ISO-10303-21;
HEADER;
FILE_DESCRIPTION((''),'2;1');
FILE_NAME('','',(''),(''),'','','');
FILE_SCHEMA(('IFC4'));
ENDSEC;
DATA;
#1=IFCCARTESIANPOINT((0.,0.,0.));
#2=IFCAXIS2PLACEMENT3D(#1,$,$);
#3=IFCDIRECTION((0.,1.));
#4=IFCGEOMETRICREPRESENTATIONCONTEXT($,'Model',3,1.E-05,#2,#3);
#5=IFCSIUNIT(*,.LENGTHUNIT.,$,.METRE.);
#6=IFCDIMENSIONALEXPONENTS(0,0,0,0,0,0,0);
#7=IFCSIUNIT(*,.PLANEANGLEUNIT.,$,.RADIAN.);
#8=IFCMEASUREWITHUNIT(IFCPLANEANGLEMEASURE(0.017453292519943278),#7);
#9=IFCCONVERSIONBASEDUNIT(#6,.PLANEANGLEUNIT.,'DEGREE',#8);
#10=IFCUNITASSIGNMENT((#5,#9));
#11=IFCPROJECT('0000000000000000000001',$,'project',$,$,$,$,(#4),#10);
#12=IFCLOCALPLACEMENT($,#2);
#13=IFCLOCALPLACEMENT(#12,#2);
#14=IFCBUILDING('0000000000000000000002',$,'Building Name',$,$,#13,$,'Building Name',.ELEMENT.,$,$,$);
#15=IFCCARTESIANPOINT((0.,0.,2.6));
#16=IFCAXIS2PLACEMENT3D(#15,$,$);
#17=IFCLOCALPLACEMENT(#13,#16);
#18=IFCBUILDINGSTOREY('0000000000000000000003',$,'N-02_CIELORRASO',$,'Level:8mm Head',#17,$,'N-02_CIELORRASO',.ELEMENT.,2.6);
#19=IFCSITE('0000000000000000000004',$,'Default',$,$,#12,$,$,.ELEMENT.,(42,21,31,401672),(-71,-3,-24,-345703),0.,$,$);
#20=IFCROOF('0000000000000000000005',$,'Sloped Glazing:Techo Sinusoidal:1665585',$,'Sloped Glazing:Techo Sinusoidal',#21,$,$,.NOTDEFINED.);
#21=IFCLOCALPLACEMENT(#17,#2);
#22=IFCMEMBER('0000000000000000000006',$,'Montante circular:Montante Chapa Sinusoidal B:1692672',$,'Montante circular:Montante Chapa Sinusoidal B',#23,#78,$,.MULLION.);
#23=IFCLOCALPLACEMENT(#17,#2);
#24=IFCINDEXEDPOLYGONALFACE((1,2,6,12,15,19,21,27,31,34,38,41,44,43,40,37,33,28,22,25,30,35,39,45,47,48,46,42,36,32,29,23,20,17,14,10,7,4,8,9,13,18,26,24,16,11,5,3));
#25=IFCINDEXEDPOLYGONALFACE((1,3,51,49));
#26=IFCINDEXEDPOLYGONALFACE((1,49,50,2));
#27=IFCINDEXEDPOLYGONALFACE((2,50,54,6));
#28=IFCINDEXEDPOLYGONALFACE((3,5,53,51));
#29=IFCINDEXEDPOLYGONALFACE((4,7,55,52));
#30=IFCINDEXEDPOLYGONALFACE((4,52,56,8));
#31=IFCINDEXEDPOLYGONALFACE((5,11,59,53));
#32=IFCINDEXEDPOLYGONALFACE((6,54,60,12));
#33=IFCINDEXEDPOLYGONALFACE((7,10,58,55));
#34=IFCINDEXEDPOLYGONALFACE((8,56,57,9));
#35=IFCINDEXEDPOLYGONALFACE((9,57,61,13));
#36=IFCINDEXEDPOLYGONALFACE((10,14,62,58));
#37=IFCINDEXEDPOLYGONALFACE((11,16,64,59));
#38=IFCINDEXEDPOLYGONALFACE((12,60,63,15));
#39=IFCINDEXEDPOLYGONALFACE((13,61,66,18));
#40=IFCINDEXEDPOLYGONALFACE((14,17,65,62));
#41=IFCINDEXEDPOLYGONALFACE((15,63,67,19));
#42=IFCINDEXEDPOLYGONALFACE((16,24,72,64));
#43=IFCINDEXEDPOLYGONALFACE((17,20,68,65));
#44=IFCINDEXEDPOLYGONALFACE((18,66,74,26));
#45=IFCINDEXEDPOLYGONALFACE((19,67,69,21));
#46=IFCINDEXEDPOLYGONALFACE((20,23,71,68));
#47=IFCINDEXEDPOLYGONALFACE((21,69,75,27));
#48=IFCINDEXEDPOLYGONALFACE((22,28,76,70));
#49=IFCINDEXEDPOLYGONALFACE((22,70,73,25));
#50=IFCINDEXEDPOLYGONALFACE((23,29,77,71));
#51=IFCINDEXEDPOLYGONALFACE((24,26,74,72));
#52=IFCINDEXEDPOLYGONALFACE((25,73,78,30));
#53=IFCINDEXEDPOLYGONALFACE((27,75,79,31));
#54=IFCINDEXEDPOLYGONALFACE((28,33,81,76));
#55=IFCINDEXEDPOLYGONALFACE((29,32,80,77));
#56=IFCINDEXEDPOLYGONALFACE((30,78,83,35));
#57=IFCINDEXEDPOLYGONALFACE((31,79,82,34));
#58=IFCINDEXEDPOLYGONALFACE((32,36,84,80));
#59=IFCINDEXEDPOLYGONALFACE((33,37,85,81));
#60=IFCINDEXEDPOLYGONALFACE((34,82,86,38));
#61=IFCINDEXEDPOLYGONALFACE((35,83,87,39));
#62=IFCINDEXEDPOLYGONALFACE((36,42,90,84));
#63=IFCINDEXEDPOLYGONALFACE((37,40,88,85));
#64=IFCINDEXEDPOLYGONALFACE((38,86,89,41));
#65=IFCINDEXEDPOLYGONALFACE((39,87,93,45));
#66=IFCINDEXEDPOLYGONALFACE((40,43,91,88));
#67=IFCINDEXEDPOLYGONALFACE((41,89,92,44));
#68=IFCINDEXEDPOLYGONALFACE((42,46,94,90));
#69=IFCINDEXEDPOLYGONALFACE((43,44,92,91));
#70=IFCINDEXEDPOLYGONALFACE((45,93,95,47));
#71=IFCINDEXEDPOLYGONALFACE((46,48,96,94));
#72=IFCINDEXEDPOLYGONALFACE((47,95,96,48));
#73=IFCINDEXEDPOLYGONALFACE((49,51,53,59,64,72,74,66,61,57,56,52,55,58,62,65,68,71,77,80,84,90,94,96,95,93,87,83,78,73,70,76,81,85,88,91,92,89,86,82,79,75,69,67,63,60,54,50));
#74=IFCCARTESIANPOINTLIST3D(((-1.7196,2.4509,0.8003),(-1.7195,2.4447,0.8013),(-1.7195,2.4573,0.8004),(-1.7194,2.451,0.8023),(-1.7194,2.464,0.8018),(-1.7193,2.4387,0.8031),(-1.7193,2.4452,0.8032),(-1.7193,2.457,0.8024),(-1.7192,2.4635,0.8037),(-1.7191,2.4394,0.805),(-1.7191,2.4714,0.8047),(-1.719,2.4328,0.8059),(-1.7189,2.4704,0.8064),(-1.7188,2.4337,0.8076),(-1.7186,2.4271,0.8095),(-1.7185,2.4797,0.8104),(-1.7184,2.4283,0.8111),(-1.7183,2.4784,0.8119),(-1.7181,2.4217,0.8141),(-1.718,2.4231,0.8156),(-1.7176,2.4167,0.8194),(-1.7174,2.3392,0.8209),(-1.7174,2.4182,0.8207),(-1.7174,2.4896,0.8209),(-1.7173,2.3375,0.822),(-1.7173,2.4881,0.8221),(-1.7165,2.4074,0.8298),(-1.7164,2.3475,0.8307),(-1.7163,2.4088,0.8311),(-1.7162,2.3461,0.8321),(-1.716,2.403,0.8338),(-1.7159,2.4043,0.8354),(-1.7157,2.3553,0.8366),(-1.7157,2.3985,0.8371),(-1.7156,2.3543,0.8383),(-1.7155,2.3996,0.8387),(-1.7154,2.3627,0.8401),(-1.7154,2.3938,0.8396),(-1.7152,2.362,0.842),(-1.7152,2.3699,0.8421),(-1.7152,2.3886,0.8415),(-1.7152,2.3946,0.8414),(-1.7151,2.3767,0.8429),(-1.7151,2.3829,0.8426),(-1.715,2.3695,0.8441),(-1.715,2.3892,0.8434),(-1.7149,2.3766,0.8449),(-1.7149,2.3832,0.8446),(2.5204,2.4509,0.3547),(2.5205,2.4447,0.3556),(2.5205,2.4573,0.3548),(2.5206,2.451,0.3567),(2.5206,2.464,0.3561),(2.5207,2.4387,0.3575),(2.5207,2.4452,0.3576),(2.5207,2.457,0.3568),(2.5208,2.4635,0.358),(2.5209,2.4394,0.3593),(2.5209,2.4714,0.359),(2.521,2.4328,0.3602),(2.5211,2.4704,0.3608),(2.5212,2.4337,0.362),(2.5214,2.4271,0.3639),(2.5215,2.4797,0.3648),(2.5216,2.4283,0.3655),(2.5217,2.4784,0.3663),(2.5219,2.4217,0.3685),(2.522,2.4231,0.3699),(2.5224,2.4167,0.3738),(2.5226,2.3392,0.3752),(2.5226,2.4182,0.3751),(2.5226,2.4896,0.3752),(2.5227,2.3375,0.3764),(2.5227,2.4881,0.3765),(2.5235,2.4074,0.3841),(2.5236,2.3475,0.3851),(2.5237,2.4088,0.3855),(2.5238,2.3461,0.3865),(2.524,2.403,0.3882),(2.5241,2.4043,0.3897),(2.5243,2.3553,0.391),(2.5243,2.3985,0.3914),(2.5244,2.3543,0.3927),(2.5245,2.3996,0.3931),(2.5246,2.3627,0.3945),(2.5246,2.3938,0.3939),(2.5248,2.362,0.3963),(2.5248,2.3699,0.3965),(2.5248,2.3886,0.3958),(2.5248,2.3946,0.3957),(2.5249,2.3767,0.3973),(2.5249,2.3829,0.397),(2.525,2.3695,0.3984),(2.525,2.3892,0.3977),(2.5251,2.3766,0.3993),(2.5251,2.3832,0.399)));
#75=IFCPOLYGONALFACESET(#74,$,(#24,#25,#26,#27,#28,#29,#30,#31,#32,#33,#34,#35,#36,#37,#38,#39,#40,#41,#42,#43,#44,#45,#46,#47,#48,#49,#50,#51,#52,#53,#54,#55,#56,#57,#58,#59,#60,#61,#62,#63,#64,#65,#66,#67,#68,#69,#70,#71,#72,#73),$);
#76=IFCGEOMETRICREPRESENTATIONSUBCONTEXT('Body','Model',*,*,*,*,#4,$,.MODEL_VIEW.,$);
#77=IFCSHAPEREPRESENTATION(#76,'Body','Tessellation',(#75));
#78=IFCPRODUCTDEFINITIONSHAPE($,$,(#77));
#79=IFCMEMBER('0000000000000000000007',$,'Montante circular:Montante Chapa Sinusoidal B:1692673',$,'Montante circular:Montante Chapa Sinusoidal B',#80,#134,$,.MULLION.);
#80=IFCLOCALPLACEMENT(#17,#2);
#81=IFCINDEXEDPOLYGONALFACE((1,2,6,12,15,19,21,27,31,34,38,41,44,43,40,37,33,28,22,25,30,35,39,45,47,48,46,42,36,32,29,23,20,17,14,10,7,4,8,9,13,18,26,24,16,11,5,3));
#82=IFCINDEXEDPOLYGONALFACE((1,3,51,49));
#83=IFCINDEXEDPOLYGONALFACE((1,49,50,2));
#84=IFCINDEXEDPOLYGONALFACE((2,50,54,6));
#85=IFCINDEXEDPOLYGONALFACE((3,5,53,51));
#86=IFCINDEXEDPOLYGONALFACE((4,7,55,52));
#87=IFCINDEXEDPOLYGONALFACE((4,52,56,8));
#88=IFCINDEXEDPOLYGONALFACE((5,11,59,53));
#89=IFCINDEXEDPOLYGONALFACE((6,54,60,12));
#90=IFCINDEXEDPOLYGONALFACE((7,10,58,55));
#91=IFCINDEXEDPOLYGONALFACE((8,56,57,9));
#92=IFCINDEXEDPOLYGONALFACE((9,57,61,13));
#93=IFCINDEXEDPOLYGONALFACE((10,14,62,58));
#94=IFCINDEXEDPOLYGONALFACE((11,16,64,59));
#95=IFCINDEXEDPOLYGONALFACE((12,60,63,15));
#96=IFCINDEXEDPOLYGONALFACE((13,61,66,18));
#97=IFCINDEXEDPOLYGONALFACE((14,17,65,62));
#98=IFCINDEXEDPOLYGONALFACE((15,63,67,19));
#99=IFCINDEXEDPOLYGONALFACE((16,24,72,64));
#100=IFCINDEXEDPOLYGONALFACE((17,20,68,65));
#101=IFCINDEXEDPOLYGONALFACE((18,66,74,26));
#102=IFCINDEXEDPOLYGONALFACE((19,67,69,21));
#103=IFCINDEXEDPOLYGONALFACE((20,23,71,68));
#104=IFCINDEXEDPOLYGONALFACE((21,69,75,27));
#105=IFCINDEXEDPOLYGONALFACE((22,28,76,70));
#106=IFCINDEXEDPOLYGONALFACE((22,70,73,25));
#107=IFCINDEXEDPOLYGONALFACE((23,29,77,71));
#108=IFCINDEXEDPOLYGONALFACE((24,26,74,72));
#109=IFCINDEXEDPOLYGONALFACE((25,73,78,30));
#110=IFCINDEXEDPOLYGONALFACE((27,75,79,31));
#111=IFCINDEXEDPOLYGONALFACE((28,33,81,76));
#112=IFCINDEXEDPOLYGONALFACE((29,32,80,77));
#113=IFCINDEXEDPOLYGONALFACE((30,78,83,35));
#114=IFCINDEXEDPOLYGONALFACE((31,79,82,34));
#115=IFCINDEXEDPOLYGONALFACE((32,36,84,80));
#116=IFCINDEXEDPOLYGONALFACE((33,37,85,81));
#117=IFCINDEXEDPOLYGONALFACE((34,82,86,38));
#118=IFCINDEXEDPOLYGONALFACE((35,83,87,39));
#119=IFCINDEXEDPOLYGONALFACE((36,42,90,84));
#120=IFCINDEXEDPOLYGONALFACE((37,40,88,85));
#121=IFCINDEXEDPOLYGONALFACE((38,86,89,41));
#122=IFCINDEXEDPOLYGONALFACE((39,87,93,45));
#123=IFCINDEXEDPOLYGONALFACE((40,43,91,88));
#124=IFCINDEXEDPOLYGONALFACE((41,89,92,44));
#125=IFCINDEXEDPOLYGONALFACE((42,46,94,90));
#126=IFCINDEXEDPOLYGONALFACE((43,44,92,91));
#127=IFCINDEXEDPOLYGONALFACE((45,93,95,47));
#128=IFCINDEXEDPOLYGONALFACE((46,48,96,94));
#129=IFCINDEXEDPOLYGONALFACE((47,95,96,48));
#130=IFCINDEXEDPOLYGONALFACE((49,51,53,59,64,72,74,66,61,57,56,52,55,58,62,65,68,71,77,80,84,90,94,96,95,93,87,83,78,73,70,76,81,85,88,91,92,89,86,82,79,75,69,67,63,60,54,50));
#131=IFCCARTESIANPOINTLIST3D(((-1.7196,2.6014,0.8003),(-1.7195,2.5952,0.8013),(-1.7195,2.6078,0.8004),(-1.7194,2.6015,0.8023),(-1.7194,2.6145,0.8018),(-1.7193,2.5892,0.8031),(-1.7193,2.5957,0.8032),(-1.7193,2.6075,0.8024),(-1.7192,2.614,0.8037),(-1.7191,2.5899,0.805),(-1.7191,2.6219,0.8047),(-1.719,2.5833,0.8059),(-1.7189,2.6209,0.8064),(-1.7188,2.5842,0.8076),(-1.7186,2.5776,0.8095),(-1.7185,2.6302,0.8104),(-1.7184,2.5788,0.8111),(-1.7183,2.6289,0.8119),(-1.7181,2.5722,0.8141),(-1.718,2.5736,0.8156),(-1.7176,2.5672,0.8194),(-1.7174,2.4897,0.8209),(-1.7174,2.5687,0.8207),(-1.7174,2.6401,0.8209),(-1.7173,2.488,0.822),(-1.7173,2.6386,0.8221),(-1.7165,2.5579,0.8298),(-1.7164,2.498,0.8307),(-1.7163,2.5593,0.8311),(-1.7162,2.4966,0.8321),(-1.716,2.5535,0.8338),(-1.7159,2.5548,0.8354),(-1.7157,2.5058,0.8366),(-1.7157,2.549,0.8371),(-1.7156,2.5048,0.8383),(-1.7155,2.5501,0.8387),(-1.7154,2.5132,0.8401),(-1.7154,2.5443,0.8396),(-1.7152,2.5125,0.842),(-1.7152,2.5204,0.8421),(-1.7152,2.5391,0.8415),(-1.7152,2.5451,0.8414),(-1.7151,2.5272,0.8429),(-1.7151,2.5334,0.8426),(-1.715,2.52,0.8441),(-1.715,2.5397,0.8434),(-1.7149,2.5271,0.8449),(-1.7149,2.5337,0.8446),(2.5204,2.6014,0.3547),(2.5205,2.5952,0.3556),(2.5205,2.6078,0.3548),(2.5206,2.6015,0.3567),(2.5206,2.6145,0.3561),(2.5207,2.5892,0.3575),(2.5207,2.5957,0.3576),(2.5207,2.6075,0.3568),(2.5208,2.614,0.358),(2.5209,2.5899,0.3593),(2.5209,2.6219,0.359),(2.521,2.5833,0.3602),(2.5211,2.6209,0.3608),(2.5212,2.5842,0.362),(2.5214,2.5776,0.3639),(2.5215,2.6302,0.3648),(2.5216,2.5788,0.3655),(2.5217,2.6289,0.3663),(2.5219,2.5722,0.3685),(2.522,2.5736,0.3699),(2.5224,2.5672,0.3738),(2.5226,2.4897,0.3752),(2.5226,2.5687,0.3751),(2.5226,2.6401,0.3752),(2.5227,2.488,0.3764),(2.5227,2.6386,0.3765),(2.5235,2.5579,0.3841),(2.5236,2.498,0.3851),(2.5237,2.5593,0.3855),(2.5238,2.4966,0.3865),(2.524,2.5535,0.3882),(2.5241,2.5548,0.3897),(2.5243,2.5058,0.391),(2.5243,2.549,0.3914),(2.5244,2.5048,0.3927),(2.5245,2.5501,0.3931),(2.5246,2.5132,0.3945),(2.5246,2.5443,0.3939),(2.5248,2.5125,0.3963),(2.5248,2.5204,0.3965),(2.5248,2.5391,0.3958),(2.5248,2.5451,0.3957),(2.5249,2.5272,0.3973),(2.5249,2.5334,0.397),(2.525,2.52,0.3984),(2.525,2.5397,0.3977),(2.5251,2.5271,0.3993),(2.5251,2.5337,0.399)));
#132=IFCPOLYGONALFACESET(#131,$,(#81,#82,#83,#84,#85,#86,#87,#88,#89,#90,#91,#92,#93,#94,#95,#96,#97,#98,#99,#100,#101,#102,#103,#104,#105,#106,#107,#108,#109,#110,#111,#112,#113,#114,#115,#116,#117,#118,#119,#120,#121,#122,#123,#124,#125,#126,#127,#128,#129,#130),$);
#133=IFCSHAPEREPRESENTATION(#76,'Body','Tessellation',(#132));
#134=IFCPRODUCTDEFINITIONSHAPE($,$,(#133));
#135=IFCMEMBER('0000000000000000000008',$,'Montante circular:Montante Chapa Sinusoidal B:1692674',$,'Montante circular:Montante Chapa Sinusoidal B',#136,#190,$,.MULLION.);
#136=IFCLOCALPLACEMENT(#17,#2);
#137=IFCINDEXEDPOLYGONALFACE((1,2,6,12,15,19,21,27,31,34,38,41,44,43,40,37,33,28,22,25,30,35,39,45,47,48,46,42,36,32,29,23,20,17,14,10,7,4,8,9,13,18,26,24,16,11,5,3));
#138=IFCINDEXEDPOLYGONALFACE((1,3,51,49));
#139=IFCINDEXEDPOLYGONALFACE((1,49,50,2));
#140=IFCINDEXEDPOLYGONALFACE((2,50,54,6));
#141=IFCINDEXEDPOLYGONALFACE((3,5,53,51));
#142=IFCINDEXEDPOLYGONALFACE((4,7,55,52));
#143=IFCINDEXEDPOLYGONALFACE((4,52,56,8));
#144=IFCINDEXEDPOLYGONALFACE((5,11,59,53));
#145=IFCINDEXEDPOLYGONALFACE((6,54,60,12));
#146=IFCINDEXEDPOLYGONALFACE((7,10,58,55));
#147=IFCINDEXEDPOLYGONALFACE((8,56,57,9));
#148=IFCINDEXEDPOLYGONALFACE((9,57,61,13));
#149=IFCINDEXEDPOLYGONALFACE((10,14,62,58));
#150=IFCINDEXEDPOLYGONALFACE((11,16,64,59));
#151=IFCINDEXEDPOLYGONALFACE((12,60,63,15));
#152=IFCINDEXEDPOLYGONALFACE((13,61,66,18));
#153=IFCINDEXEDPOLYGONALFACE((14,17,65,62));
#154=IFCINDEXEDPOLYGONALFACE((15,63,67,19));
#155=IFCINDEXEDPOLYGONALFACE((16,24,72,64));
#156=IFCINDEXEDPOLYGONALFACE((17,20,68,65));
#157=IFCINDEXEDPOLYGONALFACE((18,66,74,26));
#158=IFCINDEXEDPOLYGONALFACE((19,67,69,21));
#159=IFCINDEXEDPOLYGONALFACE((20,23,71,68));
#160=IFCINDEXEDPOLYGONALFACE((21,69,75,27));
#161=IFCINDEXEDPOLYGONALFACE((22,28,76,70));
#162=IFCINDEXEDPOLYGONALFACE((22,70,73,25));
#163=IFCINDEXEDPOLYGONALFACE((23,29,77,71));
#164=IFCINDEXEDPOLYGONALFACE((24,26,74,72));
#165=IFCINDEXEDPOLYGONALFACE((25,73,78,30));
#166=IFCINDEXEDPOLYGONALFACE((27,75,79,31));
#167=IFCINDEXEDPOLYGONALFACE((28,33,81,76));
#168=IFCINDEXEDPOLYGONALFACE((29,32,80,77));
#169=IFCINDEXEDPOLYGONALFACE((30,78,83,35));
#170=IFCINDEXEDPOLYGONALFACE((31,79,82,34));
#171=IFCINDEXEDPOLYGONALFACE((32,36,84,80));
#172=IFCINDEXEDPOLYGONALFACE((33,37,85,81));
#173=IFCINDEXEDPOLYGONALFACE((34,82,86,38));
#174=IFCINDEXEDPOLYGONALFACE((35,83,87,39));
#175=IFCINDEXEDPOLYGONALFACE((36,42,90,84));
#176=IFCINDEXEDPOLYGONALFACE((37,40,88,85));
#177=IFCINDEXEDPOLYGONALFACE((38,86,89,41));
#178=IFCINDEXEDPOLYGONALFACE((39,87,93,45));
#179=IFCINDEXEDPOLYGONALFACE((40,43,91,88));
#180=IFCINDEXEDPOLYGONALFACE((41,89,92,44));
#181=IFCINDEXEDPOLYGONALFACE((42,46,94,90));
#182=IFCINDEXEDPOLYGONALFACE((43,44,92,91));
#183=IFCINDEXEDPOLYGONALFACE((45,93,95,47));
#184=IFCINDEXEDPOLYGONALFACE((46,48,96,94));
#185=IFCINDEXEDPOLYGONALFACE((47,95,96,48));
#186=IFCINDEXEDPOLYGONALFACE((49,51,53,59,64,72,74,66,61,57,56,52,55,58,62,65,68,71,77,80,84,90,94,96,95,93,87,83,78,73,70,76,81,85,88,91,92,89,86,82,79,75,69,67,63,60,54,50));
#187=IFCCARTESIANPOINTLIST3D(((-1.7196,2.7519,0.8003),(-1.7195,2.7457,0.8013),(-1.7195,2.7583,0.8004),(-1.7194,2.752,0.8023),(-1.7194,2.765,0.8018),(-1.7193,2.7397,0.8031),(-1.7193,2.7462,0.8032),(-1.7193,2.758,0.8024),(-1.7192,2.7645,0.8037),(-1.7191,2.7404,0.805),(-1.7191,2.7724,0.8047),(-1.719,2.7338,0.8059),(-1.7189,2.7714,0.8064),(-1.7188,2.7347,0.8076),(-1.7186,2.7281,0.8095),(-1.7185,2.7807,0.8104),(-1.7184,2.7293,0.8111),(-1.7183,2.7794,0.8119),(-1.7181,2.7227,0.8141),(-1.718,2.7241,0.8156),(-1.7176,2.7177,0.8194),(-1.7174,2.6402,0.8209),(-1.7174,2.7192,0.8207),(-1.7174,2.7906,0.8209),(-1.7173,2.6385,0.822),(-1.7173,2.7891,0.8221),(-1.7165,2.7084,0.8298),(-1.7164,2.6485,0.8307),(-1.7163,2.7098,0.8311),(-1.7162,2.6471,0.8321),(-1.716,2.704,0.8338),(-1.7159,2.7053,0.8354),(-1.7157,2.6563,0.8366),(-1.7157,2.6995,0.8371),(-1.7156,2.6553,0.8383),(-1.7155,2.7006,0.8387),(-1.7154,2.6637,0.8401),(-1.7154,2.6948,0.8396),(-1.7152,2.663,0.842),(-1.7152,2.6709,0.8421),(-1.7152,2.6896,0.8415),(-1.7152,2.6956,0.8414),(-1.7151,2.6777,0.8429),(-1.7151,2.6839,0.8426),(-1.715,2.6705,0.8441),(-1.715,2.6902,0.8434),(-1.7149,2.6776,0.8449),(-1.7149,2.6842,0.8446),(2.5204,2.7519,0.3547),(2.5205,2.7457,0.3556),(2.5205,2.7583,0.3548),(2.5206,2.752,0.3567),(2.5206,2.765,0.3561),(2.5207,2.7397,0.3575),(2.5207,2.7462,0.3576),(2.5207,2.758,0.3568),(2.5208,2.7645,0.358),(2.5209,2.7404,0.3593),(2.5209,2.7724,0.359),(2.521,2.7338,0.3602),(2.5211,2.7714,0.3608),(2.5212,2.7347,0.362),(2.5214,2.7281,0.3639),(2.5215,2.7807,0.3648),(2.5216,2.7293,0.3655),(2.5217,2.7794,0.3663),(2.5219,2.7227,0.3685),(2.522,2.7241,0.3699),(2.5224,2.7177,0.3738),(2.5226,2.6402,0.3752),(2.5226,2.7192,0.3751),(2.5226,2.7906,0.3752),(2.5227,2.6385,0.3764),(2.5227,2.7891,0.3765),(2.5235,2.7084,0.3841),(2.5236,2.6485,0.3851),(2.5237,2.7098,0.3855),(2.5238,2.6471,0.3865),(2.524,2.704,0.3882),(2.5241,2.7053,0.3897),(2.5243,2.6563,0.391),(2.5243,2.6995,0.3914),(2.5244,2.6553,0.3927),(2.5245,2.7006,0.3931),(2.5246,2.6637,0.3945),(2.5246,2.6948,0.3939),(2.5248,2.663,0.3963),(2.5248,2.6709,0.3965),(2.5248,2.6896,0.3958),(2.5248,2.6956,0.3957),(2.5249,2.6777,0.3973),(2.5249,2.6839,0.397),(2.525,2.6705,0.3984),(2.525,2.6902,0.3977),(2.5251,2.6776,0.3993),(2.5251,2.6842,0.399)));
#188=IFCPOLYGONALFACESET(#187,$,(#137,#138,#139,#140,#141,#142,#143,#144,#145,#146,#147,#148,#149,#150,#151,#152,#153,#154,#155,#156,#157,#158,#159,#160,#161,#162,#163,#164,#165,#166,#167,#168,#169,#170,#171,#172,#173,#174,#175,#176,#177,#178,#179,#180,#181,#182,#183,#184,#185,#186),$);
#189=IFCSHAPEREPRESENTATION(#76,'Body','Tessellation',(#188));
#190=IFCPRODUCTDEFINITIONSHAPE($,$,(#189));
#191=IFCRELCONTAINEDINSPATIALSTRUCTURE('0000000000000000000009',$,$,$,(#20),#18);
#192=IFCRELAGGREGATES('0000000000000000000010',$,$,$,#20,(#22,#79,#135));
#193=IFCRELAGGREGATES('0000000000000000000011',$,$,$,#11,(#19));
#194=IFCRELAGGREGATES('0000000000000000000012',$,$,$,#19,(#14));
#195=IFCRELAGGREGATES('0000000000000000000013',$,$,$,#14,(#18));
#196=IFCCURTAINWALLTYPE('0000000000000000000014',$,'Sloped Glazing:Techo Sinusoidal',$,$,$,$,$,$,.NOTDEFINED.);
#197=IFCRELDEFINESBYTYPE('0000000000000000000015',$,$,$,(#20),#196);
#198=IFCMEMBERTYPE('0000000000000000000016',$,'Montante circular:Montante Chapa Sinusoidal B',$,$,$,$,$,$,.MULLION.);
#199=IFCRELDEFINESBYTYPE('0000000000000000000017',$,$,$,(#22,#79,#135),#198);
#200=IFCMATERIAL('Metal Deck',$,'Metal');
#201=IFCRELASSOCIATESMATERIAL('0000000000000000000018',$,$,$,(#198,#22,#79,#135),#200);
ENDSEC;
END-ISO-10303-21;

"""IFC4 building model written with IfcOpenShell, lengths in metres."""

from ifc_helpers import new_model, entity, si_unit, converted_unit, direction, frame, origin, place, context, subcontext, project, spatial, indexed_curve, outline, extrude, source, transform, mapped, material, type_object, type_shapes, element, aggregate, save


model = new_model("IFC4")

# Units and contexts
model_context = context("Model", 3, precision=1e-05, world=origin(), true_north=direction((0.0, 1.0)))
body_context = subcontext(model_context, "Body", "Model", "MODEL_VIEW")
ifc_project = project(units=[si_unit("LENGTHUNIT", "METRE"), converted_unit("PLANEANGLEUNIT", "DEGREE", entity("IfcPlaneAngleMeasure", 0.017453292519943278), si_unit("PLANEANGLEUNIT", "RADIAN"), dimensions=[0, 0, 0, 0, 0, 0, 0])], contexts=[model_context])

# Site, building, storey
site_placement = place(None, origin())
site = spatial("IfcSite", under=ifc_project, at=site_placement, Name="Default", CompositionType="ELEMENT", RefLatitude=(42, 21, 31, 401672), RefLongitude=(-71, -3, -24, -345703), RefElevation=0.0)
building_placement = place(site_placement, origin())
building = spatial("IfcBuilding", under=site, at=building_placement, Name="Building Name", LongName="Building Name", CompositionType="ELEMENT")
storey_placement = place(building_placement, frame((0.0, 0.0, 2.6)))
storey = spatial("IfcBuildingStorey", under=building, at=storey_placement, Name="N-02_CIELORRASO", ObjectType="Level:8mm Head", LongName="N-02_CIELORRASO", CompositionType="ELEMENT", Elevation=2.6)

# Roof, members
curtain_wall_type = type_object("IfcCurtainWallType", Name="Sloped Glazing:Techo Sinusoidal", PredefinedType="NOTDEFINED")
roof_placement = place(storey_placement, frame((0.0, 0.0, -2.6)))
roof = element("IfcRoof", 1, at=roof_placement, inside=storey, type_object=curtain_wall_type, Name="Sloped Glazing:Techo Sinusoidal:1665585", ObjectType="Sloped Glazing:Techo Sinusoidal", PredefinedType="NOTDEFINED")
ifc_material_1 = material(Name="Metal Deck", Category="Metal")
member_type = type_object("IfcMemberType", Name="Montante circular:Montante Chapa Sinusoidal B", PredefinedType="MULLION", material=ifc_material_1)
shared_shape_1 = source(origin(), body_context, "Body", "SweptSolid", [
    extrude(outline(indexed_curve([(0.0595, -0.0443), (0.0615, -0.0443), (0.0603, -0.031), (0.0572, -0.0213), (0.053, -0.0138), (0.0481, -0.0078), (0.0427, -0.003), (0.0372, 0.0005), (0.0315, 0.0029), (0.0259, 0.0044), (0.0203, 0.0051), (0.0146, 0.005), (0.0084, 0.0041), (-0.0053, 0.0009), (-0.0123, -0.0005), (-0.0191, -0.0012), (-0.0256, -0.001), (-0.0317, 0.0001), (-0.0375, 0.0019), (-0.0428, 0.0046), (-0.0477, 0.0081), (-0.0522, 0.0128), (-0.0563, 0.0191), (-0.0597, 0.0282), (-0.0617, 0.0421), (-0.0637, 0.042), (-0.0616, 0.0277), (-0.0581, 0.0182), (-0.0537, 0.0116), (-0.049, 0.0066), (-0.0438, 0.0028), (-0.0382, 0.0001), (-0.0322, -0.0019), (-0.0258, -0.003), (-0.019, -0.0032), (-0.012, -0.0025), (-0.0048, -0.0011), (0.0088, 0.0021), (0.0147, 0.003), (0.0202, 0.0031), (0.0255, 0.0024), (0.0309, 0.001), (0.0362, -0.0013), (0.0415, -0.0046), (0.0466, -0.0092), (0.0513, -0.0149), (0.0554, -0.0221), (0.0584, -0.0314), (0.0595, -0.0443)], self_intersect=False)), frame((-0.007, 0.0228, -4.2634), z_axis=(0.0, 0.0, 1.0), x_axis=(-0.819152, -0.573576, 0.0)), (0.0, 0.0, 1.0), 4.2634),
])
type_shapes(member_type, [shared_shape_1])
member_1_placement = place(roof_placement, frame((-1.7148, 2.4204, 3.4456), z_axis=(-0.994522, 0.0, 0.104528), x_axis=(0.0, 1.0, 0.0)))
member_1 = element("IfcMember", 2, at=member_1_placement, type_object=member_type, material=ifc_material_1, Name="Montante circular:Montante Chapa Sinusoidal B:1692672", ObjectType="Montante circular:Montante Chapa Sinusoidal B", PredefinedType="MULLION", context=body_context, shape_type="MappedRepresentation", body=[
    mapped(shared_shape_1, transform((0.0, 0.0, 0.0), scale=1.0)),
])
member_2_placement = place(roof_placement, frame((-1.7148, 2.5709, 3.4456), z_axis=(-0.994522, 0.0, 0.104528), x_axis=(0.0, 1.0, 0.0)))
member_2 = element("IfcMember", 3, at=member_2_placement, type_object=member_type, material=ifc_material_1, Name="Montante circular:Montante Chapa Sinusoidal B:1692673", ObjectType="Montante circular:Montante Chapa Sinusoidal B", PredefinedType="MULLION", context=body_context, shape_type="MappedRepresentation", body=[
    mapped(shared_shape_1, transform((0.0, 0.0, 0.0), scale=1.0)),
])
member_3_placement = place(roof_placement, frame((-1.7148, 2.7214, 3.4456), z_axis=(-0.994522, 0.0, 0.104528), x_axis=(0.0, 1.0, 0.0)))
member_3 = element("IfcMember", 4, at=member_3_placement, type_object=member_type, material=ifc_material_1, Name="Montante circular:Montante Chapa Sinusoidal B:1692674", ObjectType="Montante circular:Montante Chapa Sinusoidal B", PredefinedType="MULLION", context=body_context, shape_type="MappedRepresentation", body=[
    mapped(shared_shape_1, transform((0.0, 0.0, 0.0), scale=1.0)),
])
aggregate(roof, [member_1, member_2, member_3])

save(model, "model.ifc")
